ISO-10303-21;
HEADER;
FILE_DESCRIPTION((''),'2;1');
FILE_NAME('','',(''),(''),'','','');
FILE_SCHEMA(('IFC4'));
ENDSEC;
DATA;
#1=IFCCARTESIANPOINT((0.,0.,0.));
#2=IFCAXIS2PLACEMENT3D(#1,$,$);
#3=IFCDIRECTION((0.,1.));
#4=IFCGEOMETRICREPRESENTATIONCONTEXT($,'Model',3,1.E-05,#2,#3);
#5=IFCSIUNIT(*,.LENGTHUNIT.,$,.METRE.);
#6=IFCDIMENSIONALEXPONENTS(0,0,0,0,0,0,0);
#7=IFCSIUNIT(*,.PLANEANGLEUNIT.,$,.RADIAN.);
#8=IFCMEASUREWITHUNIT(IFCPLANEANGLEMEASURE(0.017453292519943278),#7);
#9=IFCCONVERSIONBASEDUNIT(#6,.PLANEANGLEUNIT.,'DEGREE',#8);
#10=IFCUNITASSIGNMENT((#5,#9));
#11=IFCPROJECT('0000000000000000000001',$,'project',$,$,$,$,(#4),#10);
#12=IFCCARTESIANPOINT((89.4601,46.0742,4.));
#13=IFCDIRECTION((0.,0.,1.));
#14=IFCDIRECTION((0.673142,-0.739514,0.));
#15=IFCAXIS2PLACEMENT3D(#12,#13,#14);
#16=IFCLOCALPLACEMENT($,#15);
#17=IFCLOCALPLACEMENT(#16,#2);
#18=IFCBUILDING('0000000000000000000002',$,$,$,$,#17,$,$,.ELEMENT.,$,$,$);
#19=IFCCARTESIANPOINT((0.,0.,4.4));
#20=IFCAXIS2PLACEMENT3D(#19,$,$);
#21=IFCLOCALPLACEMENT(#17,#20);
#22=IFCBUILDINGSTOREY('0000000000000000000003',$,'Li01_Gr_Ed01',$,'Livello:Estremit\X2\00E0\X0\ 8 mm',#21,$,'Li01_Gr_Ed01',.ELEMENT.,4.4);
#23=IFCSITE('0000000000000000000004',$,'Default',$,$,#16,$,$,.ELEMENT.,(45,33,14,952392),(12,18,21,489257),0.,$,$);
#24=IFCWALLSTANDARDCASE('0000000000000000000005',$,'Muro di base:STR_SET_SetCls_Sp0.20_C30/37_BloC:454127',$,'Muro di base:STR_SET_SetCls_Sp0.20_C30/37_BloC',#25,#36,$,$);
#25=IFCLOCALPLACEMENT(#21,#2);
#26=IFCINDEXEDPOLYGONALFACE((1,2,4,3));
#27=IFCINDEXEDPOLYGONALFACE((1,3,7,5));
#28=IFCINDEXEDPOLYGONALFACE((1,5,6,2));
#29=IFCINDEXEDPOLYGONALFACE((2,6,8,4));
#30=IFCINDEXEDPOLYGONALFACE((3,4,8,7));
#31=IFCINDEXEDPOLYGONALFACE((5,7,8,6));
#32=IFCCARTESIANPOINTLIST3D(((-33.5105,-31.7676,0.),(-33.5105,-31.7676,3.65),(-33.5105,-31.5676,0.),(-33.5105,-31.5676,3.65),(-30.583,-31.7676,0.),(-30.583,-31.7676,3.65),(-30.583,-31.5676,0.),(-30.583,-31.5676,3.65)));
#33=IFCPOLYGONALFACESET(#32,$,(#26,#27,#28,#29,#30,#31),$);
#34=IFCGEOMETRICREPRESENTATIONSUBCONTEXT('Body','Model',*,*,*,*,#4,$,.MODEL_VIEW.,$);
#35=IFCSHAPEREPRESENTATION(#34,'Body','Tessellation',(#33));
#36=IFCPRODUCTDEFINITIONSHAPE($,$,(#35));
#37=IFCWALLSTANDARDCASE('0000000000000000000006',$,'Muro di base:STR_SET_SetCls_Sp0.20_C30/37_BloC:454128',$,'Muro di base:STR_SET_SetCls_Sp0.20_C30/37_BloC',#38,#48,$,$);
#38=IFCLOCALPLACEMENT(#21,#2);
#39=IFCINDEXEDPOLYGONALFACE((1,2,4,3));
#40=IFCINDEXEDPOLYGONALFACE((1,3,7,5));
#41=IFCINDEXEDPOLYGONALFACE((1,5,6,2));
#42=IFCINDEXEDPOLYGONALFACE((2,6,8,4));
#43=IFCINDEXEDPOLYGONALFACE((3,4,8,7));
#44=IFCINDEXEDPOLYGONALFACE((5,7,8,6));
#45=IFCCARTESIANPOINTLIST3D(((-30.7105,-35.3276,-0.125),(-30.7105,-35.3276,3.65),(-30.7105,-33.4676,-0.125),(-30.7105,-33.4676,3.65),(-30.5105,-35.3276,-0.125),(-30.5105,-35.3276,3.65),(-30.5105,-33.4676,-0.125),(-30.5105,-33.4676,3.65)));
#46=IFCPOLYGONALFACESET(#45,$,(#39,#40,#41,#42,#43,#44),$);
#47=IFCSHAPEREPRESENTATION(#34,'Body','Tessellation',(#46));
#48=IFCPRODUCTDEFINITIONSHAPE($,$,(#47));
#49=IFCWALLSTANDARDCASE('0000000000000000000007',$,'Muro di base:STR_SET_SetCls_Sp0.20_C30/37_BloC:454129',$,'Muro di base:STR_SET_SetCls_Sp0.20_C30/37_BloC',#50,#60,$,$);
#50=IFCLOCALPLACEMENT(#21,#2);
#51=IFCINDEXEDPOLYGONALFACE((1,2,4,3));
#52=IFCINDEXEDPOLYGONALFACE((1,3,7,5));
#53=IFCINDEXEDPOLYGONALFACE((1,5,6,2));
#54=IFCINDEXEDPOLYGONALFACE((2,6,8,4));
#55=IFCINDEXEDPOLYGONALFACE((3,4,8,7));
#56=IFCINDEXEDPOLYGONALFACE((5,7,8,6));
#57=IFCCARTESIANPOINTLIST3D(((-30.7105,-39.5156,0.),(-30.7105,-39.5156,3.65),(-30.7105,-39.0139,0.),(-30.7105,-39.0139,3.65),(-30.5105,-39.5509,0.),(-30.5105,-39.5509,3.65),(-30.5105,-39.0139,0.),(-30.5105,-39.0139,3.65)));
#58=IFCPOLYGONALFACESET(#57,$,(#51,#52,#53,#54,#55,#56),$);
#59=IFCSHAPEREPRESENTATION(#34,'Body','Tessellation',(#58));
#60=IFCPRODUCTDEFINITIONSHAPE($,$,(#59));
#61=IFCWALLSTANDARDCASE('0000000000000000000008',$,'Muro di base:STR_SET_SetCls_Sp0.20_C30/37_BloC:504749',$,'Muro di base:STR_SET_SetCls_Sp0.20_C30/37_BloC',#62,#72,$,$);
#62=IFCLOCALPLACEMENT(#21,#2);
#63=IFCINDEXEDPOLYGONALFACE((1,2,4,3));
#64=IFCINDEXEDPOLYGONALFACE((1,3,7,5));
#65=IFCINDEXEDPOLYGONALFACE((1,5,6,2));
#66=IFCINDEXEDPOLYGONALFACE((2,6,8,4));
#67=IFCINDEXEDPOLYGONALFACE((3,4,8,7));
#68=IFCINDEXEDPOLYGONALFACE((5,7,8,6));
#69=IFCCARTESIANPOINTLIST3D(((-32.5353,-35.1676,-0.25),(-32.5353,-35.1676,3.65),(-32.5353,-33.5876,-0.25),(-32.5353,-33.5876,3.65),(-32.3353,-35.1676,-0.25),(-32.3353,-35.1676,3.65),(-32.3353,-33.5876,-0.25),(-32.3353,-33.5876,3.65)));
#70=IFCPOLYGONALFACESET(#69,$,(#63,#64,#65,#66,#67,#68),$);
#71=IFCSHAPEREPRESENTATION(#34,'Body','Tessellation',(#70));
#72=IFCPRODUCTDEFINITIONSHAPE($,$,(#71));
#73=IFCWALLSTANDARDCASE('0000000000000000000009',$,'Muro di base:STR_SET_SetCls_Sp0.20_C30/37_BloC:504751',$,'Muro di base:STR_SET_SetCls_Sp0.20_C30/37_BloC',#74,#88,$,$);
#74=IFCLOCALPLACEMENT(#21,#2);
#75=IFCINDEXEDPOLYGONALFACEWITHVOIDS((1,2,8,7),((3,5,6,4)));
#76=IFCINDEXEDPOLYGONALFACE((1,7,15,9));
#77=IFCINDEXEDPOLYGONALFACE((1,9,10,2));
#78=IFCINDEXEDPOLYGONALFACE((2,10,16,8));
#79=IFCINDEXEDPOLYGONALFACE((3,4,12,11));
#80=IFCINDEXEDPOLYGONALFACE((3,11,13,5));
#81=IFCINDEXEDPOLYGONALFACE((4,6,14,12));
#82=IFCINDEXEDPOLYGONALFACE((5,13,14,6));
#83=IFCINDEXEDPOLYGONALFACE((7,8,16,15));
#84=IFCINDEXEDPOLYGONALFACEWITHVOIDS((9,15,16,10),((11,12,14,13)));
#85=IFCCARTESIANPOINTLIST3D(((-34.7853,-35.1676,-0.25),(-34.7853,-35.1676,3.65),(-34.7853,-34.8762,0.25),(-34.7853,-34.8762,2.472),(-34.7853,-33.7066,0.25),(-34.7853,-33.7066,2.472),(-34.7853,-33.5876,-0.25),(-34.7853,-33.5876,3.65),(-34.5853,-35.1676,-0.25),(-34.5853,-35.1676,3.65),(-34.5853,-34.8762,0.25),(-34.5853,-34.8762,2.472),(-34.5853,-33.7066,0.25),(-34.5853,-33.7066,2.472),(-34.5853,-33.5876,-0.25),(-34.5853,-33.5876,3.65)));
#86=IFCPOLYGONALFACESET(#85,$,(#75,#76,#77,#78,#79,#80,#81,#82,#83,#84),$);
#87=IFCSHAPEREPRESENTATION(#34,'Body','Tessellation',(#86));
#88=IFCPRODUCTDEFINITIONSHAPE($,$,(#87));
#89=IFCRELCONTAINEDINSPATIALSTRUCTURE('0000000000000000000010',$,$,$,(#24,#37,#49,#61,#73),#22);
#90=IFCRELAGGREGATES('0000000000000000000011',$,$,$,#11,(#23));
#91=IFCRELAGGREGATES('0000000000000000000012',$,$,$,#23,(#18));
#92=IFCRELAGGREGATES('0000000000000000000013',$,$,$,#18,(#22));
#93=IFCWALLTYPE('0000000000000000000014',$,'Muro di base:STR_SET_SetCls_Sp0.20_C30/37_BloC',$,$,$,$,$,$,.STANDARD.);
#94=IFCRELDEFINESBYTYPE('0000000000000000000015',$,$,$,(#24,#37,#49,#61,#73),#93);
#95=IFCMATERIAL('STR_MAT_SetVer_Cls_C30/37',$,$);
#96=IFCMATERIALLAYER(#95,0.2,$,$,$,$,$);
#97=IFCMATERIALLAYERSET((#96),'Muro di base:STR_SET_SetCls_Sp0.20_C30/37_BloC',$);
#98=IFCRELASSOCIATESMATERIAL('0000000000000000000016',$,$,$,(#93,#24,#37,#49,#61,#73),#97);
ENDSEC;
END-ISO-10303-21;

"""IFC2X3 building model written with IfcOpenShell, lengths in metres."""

from ifc_helpers import new_model, entity, si_unit, converted_unit, direction, frame, frame_2d, origin, place, context, subcontext, project, spatial, polyline, rectangle, outline, extrude, material, layer, layer_set, layer_usage, type_object, element, save


model = new_model("IFC2X3")

# Units and contexts
model_context = context("Model", 3, precision=1e-05, world=origin(), true_north=direction((0.0, 1.0)))
body_context = subcontext(model_context, "Body", "Model", "MODEL_VIEW")
ifc_project = project(units=[si_unit("LENGTHUNIT", "METRE"), converted_unit("PLANEANGLEUNIT", "DEGREE", entity("IfcPlaneAngleMeasure", 0.017453292519943278), si_unit("PLANEANGLEUNIT", "RADIAN"), dimensions=[0, 0, 0, 0, 0, 0, 0])], contexts=[model_context])

# Site, building, storey
site_placement = place(None, frame((89.4601, 46.0742, 4.0), z_axis=(0.0, 0.0, 1.0), x_axis=(0.673142, -0.739514, 0.0)))
site = spatial("IfcSite", under=ifc_project, at=site_placement, Name="Default", CompositionType="ELEMENT", RefLatitude=(45, 33, 14, 952392), RefLongitude=(12, 18, 21, 489257), RefElevation=0.0)
building_placement = place(site_placement, origin())
building = spatial("IfcBuilding", under=site, at=building_placement, CompositionType="ELEMENT")
storey_placement = place(building_placement, frame((0.0, 0.0, 4.4)))
storey = spatial("IfcBuildingStorey", under=building, at=storey_placement, Name="Li01_Gr_Ed01", ObjectType="Livello:Estremità 8 mm", LongName="Li01_Gr_Ed01", CompositionType="ELEMENT", Elevation=4.4)

# Walls
ifc_material_1 = material(Name="STR_MAT_SetVer_Cls_C30/37")
ifc_layer_1 = layer(ifc_material_1, 0.2)
ifc_layer_set_1 = layer_set([ifc_layer_1], Name="Muro di base:STR_SET_SetCls_Sp0.20_C30/37_BloC")
ifc_layer_usage_1 = layer_usage(ifc_layer_set_1, "AXIS2", "NEGATIVE", 0.1)
wall_type = type_object("IfcWallType", Name="Muro di base:STR_SET_SetCls_Sp0.20_C30/37_BloC", PredefinedType="STANDARD", material=ifc_layer_set_1)
wall_1_placement = place(storey_placement, frame((-33.5105, -31.6676, 0.0)))
element("IfcWallStandardCase", 1, at=wall_1_placement, inside=storey, type_object=wall_type, material=ifc_layer_usage_1, Name="Muro di base:STR_SET_SetCls_Sp0.20_C30/37_BloC:454127", ObjectType="Muro di base:STR_SET_SetCls_Sp0.20_C30/37_BloC", context=body_context, shape_type="SweptSolid", body=[
    extrude(rectangle(XDim=2.9275, YDim=0.2, at=frame_2d((1.4638, 0.0), x_axis=(-1.0, 0.0))), origin(), (0.0, 0.0, 1.0), 3.65),
])
wall_2_placement = place(storey_placement, frame((-30.6105, -33.4676, -0.125), z_axis=(0.0, 0.0, 1.0), x_axis=(0.0, -1.0, 0.0)))
element("IfcWallStandardCase", 2, at=wall_2_placement, inside=storey, type_object=wall_type, material=ifc_layer_usage_1, Name="Muro di base:STR_SET_SetCls_Sp0.20_C30/37_BloC:454128", ObjectType="Muro di base:STR_SET_SetCls_Sp0.20_C30/37_BloC", context=body_context, shape_type="SweptSolid", body=[
    extrude(rectangle(XDim=1.86, YDim=0.2, at=frame_2d((0.93, 0.0), x_axis=(-1.0, 0.0))), origin(), (0.0, 0.0, 1.0), 3.775),
])
wall_3_placement = place(storey_placement, frame((-30.6105, -39.0139, 0.0), z_axis=(0.0, 0.0, 1.0), x_axis=(0.0, -1.0, 0.0)))
element("IfcWallStandardCase", 3, at=wall_3_placement, inside=storey, type_object=wall_type, material=ifc_layer_usage_1, Name="Muro di base:STR_SET_SetCls_Sp0.20_C30/37_BloC:454129", ObjectType="Muro di base:STR_SET_SetCls_Sp0.20_C30/37_BloC", context=body_context, shape_type="SweptSolid", body=[
    extrude(outline(polyline([(0.5017, -0.1), (0.537, 0.1), (0.0, 0.1), (0.0, -0.1), (0.5017, -0.1)])), origin(), (0.0, 0.0, 1.0), 3.65),
])
wall_4_placement = place(storey_placement, frame((-32.4353, -35.1676, -0.25), z_axis=(0.0, 0.0, 1.0), x_axis=(0.0, 1.0, 0.0)))
element("IfcWallStandardCase", 4, at=wall_4_placement, inside=storey, type_object=wall_type, material=ifc_layer_usage_1, Name="Muro di base:STR_SET_SetCls_Sp0.20_C30/37_BloC:504749", ObjectType="Muro di base:STR_SET_SetCls_Sp0.20_C30/37_BloC", context=body_context, shape_type="SweptSolid", body=[
    extrude(rectangle(XDim=1.58, YDim=0.2, at=frame_2d((0.79, 0.0), x_axis=(-1.0, 0.0))), origin(), (0.0, 0.0, 1.0), 3.9),
])

# Wall, opening
wall_5_placement = place(storey_placement, frame((-34.6853, -33.5876, -0.25), z_axis=(0.0, 0.0, 1.0), x_axis=(0.0, -1.0, 0.0)))
wall_5 = element("IfcWallStandardCase", 5, at=wall_5_placement, inside=storey, type_object=wall_type, material=ifc_layer_usage_1, Name="Muro di base:STR_SET_SetCls_Sp0.20_C30/37_BloC:504751", ObjectType="Muro di base:STR_SET_SetCls_Sp0.20_C30/37_BloC", context=body_context, shape_type="SweptSolid", body=[
    extrude(rectangle(XDim=1.58, YDim=0.2, at=frame_2d((0.79, 0.0), x_axis=(-1.0, 0.0))), origin(), (0.0, 0.0, 1.0), 3.9),
])
opening_placement = place(wall_5_placement, origin())
element("IfcOpeningElement", 6, at=opening_placement, cuts=wall_5, ObjectType="Opening", context=body_context, shape_type="SweptSolid", body=[
    extrude(rectangle(XDim=2.222, YDim=1.1696, at=frame_2d((0.0, 0.0), x_axis=(0.0, 1.0))), frame((0.7038, 0.1, 1.611), z_axis=(0.0, -1.0, 0.0), x_axis=(-1.0, 0.0, 0.0)), (0.0, 0.0, 1.0), 0.2),
])

save(model, "model.ifc")
